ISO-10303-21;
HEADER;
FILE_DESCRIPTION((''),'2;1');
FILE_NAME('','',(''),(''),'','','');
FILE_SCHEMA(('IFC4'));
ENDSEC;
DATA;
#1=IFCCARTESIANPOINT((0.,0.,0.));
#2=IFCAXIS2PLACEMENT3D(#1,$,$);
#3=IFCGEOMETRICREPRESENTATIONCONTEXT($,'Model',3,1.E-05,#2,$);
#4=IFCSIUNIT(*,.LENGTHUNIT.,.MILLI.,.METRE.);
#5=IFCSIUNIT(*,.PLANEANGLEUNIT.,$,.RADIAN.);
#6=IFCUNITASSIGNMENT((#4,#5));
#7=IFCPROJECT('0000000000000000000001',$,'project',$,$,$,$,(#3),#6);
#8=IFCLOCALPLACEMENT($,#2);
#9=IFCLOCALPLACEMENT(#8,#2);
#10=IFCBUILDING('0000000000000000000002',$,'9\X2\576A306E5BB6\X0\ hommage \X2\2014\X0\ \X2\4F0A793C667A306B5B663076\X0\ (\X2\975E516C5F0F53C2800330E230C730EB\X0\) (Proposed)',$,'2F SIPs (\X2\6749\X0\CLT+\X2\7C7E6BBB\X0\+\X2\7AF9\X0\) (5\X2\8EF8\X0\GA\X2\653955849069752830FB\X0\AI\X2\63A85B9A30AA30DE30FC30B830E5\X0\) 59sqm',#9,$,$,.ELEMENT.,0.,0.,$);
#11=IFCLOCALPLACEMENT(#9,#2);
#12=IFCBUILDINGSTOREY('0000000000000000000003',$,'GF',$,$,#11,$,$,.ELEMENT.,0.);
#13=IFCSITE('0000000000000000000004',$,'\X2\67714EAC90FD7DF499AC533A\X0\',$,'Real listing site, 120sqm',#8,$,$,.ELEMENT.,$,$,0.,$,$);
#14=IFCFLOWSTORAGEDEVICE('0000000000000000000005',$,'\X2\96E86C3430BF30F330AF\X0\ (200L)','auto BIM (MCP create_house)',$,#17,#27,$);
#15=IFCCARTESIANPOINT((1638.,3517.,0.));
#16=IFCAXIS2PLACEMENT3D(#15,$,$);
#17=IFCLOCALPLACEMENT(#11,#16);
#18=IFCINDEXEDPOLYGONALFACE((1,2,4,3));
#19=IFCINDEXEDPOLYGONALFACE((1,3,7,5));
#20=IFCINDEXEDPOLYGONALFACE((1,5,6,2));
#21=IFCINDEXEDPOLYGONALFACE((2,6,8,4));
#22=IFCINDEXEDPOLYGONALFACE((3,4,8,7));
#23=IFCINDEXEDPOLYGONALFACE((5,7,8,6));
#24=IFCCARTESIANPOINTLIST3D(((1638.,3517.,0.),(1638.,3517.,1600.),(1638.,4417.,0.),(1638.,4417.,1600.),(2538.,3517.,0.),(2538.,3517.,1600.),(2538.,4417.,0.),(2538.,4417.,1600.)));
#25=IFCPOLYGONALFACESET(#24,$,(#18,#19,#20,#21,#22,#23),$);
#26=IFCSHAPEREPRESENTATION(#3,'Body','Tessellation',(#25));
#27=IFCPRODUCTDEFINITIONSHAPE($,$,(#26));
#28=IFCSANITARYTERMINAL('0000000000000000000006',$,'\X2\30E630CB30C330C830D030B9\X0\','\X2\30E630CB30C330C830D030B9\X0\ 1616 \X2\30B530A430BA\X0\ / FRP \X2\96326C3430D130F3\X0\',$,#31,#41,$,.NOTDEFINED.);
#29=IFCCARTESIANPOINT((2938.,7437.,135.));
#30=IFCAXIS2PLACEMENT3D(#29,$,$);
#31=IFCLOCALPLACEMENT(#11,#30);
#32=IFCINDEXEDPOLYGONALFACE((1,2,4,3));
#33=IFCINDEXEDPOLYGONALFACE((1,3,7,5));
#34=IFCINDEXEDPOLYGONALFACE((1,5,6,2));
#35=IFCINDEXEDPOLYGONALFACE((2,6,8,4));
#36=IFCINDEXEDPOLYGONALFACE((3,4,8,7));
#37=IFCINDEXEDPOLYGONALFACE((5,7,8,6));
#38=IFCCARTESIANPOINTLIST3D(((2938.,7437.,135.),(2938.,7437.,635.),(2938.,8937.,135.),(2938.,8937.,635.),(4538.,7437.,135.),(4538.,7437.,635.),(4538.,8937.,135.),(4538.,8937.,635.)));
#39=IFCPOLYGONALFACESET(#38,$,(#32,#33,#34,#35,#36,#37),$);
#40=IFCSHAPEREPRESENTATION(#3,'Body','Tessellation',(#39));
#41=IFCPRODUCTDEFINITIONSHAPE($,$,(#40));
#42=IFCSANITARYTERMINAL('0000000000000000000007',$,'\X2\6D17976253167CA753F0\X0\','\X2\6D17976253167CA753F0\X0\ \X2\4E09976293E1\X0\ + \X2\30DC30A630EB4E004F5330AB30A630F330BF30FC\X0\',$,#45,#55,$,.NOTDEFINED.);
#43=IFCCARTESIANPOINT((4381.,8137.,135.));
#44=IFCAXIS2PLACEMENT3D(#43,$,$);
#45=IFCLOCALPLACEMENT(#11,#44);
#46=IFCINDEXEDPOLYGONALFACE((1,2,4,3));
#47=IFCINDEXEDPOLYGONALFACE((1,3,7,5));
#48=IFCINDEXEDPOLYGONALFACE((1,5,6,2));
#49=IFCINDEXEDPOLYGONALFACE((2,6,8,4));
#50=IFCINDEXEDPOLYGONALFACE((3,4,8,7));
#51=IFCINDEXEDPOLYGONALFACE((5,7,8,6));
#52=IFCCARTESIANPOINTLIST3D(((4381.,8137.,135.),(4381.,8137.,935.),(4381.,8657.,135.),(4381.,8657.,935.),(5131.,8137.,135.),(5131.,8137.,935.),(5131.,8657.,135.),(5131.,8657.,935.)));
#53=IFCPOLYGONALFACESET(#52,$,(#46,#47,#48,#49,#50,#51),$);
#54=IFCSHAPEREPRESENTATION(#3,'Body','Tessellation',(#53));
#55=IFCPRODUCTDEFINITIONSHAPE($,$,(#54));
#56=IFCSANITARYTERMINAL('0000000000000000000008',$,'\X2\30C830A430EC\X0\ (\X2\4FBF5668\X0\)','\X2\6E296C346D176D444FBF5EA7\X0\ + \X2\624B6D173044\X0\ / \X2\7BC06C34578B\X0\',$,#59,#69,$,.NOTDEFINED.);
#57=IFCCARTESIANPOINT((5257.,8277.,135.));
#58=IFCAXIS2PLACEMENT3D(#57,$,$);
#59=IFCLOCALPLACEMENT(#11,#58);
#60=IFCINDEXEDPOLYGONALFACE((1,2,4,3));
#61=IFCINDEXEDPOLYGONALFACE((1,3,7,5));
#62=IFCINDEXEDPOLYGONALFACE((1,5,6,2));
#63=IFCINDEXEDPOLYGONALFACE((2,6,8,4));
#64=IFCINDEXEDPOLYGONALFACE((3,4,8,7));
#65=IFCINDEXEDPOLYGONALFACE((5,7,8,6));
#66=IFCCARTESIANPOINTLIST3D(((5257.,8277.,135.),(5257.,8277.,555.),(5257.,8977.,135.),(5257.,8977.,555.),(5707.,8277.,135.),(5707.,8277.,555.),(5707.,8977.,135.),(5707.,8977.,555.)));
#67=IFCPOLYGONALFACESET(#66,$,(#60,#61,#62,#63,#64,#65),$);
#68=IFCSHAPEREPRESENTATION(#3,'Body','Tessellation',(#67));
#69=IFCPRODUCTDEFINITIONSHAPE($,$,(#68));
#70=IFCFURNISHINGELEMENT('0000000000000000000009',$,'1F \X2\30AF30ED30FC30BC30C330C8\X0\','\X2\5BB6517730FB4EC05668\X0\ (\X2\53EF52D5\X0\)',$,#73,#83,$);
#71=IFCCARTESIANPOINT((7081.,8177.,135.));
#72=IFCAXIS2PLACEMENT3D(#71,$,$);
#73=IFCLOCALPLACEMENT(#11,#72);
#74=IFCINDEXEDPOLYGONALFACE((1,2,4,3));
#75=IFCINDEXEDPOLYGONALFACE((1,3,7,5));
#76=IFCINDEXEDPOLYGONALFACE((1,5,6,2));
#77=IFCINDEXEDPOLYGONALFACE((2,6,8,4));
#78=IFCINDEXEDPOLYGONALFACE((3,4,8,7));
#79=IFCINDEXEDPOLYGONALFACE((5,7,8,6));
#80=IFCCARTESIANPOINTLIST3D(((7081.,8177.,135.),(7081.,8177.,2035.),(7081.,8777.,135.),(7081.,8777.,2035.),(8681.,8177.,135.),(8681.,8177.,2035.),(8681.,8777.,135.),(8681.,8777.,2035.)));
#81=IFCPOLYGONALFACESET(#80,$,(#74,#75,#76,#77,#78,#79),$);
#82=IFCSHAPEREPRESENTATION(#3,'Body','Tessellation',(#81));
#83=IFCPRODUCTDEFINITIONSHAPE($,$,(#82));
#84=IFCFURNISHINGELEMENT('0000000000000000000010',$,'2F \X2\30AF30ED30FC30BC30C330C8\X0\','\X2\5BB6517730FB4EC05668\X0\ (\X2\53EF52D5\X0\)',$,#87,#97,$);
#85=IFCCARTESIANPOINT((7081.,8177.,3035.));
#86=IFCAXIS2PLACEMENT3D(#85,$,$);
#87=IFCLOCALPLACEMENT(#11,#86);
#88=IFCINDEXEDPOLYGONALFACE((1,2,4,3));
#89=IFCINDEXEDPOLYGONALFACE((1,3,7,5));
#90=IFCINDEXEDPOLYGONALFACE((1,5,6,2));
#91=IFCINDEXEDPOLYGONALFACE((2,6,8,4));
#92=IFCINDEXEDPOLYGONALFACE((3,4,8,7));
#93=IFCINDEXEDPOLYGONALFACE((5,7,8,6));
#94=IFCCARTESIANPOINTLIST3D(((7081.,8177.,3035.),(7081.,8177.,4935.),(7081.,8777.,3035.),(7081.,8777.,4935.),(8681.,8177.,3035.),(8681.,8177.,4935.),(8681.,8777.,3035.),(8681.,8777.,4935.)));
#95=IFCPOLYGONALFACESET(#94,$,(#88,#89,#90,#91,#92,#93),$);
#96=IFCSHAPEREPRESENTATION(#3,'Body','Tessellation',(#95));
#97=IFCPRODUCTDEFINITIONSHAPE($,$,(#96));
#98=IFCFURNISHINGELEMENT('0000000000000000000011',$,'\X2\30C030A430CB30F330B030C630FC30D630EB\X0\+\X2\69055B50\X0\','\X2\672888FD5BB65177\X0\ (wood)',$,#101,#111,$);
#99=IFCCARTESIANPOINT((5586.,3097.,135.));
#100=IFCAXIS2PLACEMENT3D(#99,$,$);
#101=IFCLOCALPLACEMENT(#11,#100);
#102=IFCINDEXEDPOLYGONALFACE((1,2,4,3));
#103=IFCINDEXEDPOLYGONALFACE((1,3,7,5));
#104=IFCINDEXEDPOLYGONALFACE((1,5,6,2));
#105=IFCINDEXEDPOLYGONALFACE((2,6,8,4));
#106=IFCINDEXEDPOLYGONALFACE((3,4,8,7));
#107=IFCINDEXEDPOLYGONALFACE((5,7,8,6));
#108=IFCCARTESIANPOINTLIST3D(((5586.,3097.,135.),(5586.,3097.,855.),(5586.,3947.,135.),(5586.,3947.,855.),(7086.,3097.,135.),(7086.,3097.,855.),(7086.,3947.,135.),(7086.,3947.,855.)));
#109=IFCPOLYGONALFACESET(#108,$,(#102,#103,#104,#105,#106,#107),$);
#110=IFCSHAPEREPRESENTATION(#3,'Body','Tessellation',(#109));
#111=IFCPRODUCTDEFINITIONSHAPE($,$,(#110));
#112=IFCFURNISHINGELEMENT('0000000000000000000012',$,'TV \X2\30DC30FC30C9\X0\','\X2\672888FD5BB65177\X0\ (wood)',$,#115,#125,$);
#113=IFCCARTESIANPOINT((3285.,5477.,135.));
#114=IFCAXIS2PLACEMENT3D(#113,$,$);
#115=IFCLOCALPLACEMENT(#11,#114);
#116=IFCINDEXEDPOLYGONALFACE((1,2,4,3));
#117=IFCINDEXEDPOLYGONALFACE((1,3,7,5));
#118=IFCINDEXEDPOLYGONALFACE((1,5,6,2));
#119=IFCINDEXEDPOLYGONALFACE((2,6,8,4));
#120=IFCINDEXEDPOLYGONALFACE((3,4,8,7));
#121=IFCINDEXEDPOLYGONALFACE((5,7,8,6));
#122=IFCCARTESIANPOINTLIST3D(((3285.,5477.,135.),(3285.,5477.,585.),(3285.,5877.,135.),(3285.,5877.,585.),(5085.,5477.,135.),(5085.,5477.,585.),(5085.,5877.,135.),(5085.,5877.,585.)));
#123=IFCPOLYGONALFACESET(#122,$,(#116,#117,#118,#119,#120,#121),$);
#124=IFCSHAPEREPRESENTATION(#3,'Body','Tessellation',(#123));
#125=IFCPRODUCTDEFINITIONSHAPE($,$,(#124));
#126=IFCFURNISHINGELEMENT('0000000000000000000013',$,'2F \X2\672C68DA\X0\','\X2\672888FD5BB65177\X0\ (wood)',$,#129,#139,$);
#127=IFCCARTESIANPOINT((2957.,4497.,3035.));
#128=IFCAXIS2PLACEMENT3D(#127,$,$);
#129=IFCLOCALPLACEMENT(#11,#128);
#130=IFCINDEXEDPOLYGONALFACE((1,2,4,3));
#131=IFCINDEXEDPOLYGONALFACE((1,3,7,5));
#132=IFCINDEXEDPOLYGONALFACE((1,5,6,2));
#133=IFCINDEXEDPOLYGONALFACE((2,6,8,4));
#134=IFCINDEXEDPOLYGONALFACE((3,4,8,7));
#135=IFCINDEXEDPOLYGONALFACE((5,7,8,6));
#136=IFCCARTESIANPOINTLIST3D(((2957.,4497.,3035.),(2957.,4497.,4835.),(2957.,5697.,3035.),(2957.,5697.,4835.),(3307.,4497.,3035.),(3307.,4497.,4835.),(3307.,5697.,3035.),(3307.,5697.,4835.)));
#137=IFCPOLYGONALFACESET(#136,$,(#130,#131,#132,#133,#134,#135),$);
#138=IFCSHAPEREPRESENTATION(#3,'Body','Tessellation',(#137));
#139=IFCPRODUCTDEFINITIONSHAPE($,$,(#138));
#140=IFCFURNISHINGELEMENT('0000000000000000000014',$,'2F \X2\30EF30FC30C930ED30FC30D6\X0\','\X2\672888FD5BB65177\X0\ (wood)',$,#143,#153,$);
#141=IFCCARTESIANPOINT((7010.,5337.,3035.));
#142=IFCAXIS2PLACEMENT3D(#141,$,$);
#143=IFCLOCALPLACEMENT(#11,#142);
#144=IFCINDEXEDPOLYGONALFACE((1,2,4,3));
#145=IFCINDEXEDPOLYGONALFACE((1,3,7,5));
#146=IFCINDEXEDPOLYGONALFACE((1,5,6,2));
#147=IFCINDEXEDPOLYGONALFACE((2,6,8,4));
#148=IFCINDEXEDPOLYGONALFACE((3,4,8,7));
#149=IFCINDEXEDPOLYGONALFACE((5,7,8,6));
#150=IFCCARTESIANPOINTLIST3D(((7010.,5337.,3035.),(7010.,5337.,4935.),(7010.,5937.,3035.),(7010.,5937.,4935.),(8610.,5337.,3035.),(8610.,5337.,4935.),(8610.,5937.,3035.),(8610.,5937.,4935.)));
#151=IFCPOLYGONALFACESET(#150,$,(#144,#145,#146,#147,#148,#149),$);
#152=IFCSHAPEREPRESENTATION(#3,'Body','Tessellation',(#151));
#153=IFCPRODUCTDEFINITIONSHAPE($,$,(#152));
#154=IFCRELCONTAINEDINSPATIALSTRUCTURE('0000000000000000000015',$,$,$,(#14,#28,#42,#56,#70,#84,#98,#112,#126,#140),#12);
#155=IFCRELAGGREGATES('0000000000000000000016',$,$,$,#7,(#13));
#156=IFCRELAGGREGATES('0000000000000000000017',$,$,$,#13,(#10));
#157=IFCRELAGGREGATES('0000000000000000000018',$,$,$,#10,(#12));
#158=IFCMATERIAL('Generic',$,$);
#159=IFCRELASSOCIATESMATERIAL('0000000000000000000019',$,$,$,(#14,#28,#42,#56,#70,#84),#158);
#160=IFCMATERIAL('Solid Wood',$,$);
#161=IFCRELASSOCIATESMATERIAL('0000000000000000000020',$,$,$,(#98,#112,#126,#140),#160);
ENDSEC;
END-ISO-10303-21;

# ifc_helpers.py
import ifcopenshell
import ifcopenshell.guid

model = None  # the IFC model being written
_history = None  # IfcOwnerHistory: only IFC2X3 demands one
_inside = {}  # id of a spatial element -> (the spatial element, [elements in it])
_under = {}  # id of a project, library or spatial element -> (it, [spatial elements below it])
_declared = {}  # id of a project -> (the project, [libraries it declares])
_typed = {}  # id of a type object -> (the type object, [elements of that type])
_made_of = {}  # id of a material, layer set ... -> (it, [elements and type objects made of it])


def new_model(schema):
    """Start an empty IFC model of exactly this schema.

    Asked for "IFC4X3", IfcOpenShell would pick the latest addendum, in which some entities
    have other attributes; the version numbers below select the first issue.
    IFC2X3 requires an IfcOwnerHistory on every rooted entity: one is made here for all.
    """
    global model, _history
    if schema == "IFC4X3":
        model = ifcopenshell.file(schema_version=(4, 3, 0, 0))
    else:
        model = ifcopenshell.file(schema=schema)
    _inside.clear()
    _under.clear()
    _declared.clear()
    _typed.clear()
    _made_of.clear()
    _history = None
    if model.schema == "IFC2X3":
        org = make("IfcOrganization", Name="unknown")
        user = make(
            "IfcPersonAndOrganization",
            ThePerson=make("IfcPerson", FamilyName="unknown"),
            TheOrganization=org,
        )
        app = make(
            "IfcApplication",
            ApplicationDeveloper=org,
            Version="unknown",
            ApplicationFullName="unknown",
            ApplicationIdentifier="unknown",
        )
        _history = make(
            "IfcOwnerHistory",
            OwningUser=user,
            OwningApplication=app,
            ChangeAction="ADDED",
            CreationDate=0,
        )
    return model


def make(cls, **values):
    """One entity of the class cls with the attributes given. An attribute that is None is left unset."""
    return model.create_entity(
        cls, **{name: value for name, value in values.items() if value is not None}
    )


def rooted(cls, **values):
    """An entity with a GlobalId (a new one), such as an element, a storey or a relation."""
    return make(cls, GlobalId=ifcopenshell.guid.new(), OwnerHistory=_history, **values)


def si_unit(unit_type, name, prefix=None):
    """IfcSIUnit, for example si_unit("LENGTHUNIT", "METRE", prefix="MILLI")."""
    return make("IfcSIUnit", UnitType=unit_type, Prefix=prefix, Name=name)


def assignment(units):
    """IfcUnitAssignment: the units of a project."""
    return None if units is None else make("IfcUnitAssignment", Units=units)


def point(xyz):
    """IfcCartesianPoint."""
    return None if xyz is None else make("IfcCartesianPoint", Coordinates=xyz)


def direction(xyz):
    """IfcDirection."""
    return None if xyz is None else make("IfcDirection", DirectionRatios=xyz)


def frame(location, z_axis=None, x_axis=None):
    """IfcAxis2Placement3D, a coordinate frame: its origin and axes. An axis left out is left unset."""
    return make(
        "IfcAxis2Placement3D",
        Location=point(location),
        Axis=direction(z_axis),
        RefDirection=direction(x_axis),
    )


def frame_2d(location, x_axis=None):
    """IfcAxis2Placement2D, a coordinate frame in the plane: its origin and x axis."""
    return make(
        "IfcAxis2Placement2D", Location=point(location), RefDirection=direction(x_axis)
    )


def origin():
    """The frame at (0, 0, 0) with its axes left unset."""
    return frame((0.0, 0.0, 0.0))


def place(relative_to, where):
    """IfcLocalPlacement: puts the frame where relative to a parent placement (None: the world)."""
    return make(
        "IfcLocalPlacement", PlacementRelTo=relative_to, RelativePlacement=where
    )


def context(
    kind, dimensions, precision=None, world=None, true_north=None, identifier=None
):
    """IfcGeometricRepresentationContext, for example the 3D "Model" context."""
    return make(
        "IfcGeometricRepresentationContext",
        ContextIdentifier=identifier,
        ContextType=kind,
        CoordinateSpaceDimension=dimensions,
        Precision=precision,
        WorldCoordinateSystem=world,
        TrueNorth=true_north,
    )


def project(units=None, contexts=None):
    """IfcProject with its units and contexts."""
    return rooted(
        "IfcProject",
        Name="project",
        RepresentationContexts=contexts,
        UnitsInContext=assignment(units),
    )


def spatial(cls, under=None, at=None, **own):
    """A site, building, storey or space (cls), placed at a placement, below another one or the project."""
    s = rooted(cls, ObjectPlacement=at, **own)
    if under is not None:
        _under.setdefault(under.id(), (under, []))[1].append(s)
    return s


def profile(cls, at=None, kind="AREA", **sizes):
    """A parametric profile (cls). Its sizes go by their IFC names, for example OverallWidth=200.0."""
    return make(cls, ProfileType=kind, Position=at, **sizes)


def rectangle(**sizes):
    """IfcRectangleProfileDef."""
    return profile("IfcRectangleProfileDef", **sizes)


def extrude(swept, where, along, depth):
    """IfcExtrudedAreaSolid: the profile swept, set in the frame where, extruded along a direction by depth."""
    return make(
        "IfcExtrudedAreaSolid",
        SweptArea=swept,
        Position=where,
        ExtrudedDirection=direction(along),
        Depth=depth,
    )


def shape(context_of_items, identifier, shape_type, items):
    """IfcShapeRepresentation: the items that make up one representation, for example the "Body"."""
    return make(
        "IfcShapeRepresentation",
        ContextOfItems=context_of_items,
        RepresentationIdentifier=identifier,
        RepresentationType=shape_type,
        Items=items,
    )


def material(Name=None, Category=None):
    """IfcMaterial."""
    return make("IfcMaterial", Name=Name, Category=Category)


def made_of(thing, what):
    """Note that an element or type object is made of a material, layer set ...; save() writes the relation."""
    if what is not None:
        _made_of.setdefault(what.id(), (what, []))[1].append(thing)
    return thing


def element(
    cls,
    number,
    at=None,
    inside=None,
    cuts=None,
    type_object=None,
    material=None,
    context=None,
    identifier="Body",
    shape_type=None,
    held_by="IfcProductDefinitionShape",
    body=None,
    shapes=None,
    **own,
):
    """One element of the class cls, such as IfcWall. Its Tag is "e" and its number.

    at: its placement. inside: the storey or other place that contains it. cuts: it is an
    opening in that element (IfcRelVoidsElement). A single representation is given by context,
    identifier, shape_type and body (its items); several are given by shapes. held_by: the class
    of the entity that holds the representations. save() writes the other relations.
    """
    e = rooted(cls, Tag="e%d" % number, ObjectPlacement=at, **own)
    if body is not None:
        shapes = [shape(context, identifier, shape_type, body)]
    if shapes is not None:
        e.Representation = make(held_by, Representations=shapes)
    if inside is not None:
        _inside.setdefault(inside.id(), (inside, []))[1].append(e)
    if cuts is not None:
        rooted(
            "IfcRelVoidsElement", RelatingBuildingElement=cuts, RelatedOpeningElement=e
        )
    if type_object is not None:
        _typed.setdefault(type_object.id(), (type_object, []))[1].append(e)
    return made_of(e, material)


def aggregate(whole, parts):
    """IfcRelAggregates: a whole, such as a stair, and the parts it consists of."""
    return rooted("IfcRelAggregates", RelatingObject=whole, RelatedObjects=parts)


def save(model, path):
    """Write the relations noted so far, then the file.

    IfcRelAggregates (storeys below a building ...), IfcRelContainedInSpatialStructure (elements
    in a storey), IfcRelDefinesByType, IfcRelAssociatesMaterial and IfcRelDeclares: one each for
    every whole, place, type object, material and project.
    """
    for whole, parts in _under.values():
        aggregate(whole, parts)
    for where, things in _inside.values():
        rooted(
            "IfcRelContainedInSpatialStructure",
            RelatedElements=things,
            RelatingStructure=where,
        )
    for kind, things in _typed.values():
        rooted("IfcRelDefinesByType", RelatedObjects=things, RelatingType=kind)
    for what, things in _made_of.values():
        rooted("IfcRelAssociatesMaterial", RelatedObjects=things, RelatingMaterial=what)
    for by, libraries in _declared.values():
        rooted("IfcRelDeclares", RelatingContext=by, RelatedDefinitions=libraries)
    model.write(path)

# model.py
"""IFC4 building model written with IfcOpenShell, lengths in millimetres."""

from ifc_helpers import new_model, si_unit, frame, frame_2d, origin, place, context, project, spatial, rectangle, extrude, material, element, save


model = new_model("IFC4")

# Units and contexts
model_context = context("Model", 3, precision=1e-05, world=origin())
ifc_project = project(units=[si_unit("LENGTHUNIT", "METRE", prefix="MILLI"), si_unit("PLANEANGLEUNIT", "RADIAN")], contexts=[model_context])

# Site, building, storey
site_placement = place(None, origin())
site = spatial("IfcSite", under=ifc_project, at=site_placement, Name="東京都練馬区", ObjectType="Real listing site, 120sqm", CompositionType="ELEMENT", RefElevation=0.0)
building_placement = place(site_placement, origin())
building = spatial("IfcBuilding", under=site, at=building_placement, Name="9坪の家 hommage — 伊礼智に学ぶ (非公式参考モデル) (Proposed)", ObjectType="2F SIPs (杉CLT+籾殻+竹) (5軸GA改善適用・AI推定オマージュ) 59sqm", CompositionType="ELEMENT", ElevationOfRefHeight=0.0, ElevationOfTerrain=0.0)
storey_placement = place(building_placement, origin())
storey = spatial("IfcBuildingStorey", under=building, at=storey_placement, Name="GF", CompositionType="ELEMENT", Elevation=0.0)

# Shared definitions
ifc_material_1 = material(Name="Solid Wood")

# Flow storage device
ifc_material_2 = material(Name="Generic")
flow_storage_device_placement = place(storey_placement, frame((1638.0, 3517.0, 0.0)))
element("IfcFlowStorageDevice", 1, at=flow_storage_device_placement, inside=storey, material=ifc_material_2, Name="雨水タンク (200L)", Description="auto BIM (MCP create_house)", context=model_context, shape_type="SweptSolid", body=[
    extrude(rectangle(XDim=900.0, YDim=900.0, at=frame_2d((450.0, 450.0))), frame((1638.0, 3517.0, 0.0)), (0.0, 0.0, 1.0), 1600.0),
])

# Sanitary terminals
sanitary_terminal_1_placement = place(storey_placement, frame((2938.0, 7437.0, 135.0)))
element("IfcSanitaryTerminal", 2, at=sanitary_terminal_1_placement, inside=storey, material=ifc_material_2, Name="ユニットバス", Description="ユニットバス 1616 サイズ / FRP 防水パン", PredefinedType="NOTDEFINED", context=model_context, shape_type="SweptSolid", body=[
    extrude(rectangle(XDim=1600.0, YDim=1500.0, at=frame_2d((800.0, 750.0))), frame((2938.0, 7437.0, 135.0)), (0.0, 0.0, 1.0), 500.0),
])
sanitary_terminal_2_placement = place(storey_placement, frame((4381.0, 8137.0, 135.0)))
element("IfcSanitaryTerminal", 3, at=sanitary_terminal_2_placement, inside=storey, material=ifc_material_2, Name="洗面化粧台", Description="洗面化粧台 三面鏡 + ボウル一体カウンター", PredefinedType="NOTDEFINED", context=model_context, shape_type="SweptSolid", body=[
    extrude(rectangle(XDim=750.0, YDim=520.0, at=frame_2d((375.0, 260.0))), frame((4381.0, 8137.0, 135.0)), (0.0, 0.0, 1.0), 800.0),
])
sanitary_terminal_3_placement = place(storey_placement, frame((5257.0, 8277.0, 135.0)))
element("IfcSanitaryTerminal", 4, at=sanitary_terminal_3_placement, inside=storey, material=ifc_material_2, Name="トイレ (便器)", Description="温水洗浄便座 + 手洗い / 節水型", PredefinedType="NOTDEFINED", context=model_context, shape_type="SweptSolid", body=[
    extrude(rectangle(XDim=450.0, YDim=700.0, at=frame_2d((225.0, 350.0))), frame((5257.0, 8277.0, 135.0)), (0.0, 0.0, 1.0), 420.0),
])

# Furnishing elements
furnishing_1_placement = place(storey_placement, frame((7081.0, 8177.0, 135.0)))
element("IfcFurnishingElement", 5, at=furnishing_1_placement, inside=storey, material=ifc_material_2, Name="1F クローゼット", Description="家具・什器 (可動)", context=model_context, shape_type="SweptSolid", body=[
    extrude(rectangle(XDim=1600.0, YDim=600.0, at=frame_2d((800.0, 300.0))), frame((7081.0, 8177.0, 135.0)), (0.0, 0.0, 1.0), 1900.0),
])
furnishing_2_placement = place(storey_placement, frame((7081.0, 8177.0, 3035.0)))
element("IfcFurnishingElement", 6, at=furnishing_2_placement, inside=storey, material=ifc_material_2, Name="2F クローゼット", Description="家具・什器 (可動)", context=model_context, shape_type="SweptSolid", body=[
    extrude(rectangle(XDim=1600.0, YDim=600.0, at=frame_2d((800.0, 300.0))), frame((7081.0, 8177.0, 3035.0)), (0.0, 0.0, 1.0), 1900.0),
])
furnishing_3_placement = place(storey_placement, frame((5586.0, 3097.0, 135.0)))
element("IfcFurnishingElement", 7, at=furnishing_3_placement, inside=storey, material=ifc_material_1, Name="ダイニングテーブル+椅子", Description="木製家具 (wood)", context=model_context, shape_type="SweptSolid", body=[
    extrude(rectangle(XDim=1500.0, YDim=850.0, at=frame_2d((750.0, 425.0))), frame((5586.0, 3097.0, 135.0)), (0.0, 0.0, 1.0), 720.0),
])
furnishing_4_placement = place(storey_placement, frame((3285.0, 5477.0, 135.0)))
element("IfcFurnishingElement", 8, at=furnishing_4_placement, inside=storey, material=ifc_material_1, Name="TV ボード", Description="木製家具 (wood)", context=model_context, shape_type="SweptSolid", body=[
    extrude(rectangle(XDim=1800.0, YDim=400.0, at=frame_2d((900.0, 200.0))), frame((3285.0, 5477.0, 135.0)), (0.0, 0.0, 1.0), 450.0),
])
furnishing_5_placement = place(storey_placement, frame((2957.0, 4497.0, 3035.0)))
element("IfcFurnishingElement", 9, at=furnishing_5_placement, inside=storey, material=ifc_material_1, Name="2F 本棚", Description="木製家具 (wood)", context=model_context, shape_type="SweptSolid", body=[
    extrude(rectangle(XDim=350.0, YDim=1200.0, at=frame_2d((175.0, 600.0))), frame((2957.0, 4497.0, 3035.0)), (0.0, 0.0, 1.0), 1800.0),
])
furnishing_6_placement = place(storey_placement, frame((7010.0, 5337.0, 3035.0)))
element("IfcFurnishingElement", 10, at=furnishing_6_placement, inside=storey, material=ifc_material_1, Name="2F ワードローブ", Description="木製家具 (wood)", context=model_context, shape_type="SweptSolid", body=[
    extrude(rectangle(XDim=1600.0, YDim=600.0, at=frame_2d((800.0, 300.0))), frame((7010.0, 5337.0, 3035.0)), (0.0, 0.0, 1.0), 1900.0),
])

save(model, "model.ifc")
